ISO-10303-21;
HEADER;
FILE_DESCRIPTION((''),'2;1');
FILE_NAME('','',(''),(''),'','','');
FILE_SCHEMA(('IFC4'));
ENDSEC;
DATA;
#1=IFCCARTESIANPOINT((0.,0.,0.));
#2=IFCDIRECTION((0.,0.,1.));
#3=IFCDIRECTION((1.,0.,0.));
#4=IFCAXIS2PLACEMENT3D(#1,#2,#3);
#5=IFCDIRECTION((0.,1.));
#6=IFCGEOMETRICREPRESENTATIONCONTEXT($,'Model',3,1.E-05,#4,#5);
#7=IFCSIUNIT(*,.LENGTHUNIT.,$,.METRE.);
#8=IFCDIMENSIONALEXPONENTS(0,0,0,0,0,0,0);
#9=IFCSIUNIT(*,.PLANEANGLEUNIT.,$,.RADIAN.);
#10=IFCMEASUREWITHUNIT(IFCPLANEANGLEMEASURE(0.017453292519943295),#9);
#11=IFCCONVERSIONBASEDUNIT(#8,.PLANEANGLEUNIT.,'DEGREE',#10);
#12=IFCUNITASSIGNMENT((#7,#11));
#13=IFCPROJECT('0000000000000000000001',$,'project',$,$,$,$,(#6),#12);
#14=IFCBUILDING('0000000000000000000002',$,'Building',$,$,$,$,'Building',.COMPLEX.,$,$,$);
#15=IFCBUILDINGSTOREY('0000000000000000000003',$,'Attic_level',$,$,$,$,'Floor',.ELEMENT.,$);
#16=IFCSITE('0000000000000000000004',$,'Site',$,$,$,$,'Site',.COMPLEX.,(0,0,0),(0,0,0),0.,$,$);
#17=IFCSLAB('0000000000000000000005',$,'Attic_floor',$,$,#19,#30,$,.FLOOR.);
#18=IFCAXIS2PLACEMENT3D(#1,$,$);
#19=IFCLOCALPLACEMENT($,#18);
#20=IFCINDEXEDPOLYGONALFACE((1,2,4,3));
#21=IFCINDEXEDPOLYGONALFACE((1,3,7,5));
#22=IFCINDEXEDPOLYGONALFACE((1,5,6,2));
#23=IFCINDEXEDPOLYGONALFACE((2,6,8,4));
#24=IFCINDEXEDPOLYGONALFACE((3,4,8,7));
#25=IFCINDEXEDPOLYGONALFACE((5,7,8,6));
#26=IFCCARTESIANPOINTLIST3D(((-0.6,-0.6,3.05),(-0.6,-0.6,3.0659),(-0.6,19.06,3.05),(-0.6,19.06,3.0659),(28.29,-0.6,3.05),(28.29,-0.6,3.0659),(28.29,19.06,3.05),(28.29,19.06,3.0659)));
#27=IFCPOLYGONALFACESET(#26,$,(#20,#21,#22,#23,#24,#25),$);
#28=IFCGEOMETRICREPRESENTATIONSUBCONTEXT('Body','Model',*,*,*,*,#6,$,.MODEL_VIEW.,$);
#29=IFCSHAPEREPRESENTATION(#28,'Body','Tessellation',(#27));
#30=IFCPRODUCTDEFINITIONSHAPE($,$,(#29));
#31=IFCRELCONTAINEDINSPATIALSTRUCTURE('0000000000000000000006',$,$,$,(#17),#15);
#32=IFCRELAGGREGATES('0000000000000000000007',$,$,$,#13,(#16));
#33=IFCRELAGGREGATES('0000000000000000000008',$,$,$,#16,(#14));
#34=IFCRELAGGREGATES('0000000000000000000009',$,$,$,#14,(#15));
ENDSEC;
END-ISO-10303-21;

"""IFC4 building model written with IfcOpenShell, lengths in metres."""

from ifc_helpers import new_model, entity, si_unit, converted_unit, direction, frame, frame_2d, origin_with_axes, place, context, subcontext, project, spatial, rectangle, extrude, element, save


model = new_model("IFC4")

# Units and contexts
model_context = context("Model", 3, precision=1e-05, world=origin_with_axes(), true_north=direction((0.0, 1.0)))
body_context = subcontext(model_context, "Body", "Model", "MODEL_VIEW")
ifc_project = project(units=[si_unit("LENGTHUNIT", "METRE"), converted_unit("PLANEANGLEUNIT", "DEGREE", entity("IfcPlaneAngleMeasure", 0.017453292519943295), si_unit("PLANEANGLEUNIT", "RADIAN"), dimensions=[0, 0, 0, 0, 0, 0, 0])], contexts=[model_context])

# Site, building, storey
site = spatial("IfcSite", under=ifc_project, Name="Site", LongName="Site", CompositionType="COMPLEX", RefLatitude=(0, 0, 0), RefLongitude=(0, 0, 0), RefElevation=0.0)
building = spatial("IfcBuilding", under=site, Name="Building", LongName="Building", CompositionType="COMPLEX")
storey = spatial("IfcBuildingStorey", under=building, Name="Attic_level", LongName="Floor", CompositionType="ELEMENT")

# Slab
placement = place(None, origin_with_axes())
element("IfcSlab", 1, at=placement, inside=storey, Name="Attic_floor", PredefinedType="FLOOR", context=body_context, shape_type="SweptSolid", body=[
    extrude(rectangle(XDim=19.66, YDim=28.89, at=frame_2d((0.0, 0.0), x_axis=(0.0, 1.0))), frame((13.845, 9.23, 3.05), z_axis=(0.0, 0.0, 1.0), x_axis=(1.0, 0.0, 0.0)), (0.0, 0.0, 1.0), 0.0159),
])

save(model, "model.ifc")
